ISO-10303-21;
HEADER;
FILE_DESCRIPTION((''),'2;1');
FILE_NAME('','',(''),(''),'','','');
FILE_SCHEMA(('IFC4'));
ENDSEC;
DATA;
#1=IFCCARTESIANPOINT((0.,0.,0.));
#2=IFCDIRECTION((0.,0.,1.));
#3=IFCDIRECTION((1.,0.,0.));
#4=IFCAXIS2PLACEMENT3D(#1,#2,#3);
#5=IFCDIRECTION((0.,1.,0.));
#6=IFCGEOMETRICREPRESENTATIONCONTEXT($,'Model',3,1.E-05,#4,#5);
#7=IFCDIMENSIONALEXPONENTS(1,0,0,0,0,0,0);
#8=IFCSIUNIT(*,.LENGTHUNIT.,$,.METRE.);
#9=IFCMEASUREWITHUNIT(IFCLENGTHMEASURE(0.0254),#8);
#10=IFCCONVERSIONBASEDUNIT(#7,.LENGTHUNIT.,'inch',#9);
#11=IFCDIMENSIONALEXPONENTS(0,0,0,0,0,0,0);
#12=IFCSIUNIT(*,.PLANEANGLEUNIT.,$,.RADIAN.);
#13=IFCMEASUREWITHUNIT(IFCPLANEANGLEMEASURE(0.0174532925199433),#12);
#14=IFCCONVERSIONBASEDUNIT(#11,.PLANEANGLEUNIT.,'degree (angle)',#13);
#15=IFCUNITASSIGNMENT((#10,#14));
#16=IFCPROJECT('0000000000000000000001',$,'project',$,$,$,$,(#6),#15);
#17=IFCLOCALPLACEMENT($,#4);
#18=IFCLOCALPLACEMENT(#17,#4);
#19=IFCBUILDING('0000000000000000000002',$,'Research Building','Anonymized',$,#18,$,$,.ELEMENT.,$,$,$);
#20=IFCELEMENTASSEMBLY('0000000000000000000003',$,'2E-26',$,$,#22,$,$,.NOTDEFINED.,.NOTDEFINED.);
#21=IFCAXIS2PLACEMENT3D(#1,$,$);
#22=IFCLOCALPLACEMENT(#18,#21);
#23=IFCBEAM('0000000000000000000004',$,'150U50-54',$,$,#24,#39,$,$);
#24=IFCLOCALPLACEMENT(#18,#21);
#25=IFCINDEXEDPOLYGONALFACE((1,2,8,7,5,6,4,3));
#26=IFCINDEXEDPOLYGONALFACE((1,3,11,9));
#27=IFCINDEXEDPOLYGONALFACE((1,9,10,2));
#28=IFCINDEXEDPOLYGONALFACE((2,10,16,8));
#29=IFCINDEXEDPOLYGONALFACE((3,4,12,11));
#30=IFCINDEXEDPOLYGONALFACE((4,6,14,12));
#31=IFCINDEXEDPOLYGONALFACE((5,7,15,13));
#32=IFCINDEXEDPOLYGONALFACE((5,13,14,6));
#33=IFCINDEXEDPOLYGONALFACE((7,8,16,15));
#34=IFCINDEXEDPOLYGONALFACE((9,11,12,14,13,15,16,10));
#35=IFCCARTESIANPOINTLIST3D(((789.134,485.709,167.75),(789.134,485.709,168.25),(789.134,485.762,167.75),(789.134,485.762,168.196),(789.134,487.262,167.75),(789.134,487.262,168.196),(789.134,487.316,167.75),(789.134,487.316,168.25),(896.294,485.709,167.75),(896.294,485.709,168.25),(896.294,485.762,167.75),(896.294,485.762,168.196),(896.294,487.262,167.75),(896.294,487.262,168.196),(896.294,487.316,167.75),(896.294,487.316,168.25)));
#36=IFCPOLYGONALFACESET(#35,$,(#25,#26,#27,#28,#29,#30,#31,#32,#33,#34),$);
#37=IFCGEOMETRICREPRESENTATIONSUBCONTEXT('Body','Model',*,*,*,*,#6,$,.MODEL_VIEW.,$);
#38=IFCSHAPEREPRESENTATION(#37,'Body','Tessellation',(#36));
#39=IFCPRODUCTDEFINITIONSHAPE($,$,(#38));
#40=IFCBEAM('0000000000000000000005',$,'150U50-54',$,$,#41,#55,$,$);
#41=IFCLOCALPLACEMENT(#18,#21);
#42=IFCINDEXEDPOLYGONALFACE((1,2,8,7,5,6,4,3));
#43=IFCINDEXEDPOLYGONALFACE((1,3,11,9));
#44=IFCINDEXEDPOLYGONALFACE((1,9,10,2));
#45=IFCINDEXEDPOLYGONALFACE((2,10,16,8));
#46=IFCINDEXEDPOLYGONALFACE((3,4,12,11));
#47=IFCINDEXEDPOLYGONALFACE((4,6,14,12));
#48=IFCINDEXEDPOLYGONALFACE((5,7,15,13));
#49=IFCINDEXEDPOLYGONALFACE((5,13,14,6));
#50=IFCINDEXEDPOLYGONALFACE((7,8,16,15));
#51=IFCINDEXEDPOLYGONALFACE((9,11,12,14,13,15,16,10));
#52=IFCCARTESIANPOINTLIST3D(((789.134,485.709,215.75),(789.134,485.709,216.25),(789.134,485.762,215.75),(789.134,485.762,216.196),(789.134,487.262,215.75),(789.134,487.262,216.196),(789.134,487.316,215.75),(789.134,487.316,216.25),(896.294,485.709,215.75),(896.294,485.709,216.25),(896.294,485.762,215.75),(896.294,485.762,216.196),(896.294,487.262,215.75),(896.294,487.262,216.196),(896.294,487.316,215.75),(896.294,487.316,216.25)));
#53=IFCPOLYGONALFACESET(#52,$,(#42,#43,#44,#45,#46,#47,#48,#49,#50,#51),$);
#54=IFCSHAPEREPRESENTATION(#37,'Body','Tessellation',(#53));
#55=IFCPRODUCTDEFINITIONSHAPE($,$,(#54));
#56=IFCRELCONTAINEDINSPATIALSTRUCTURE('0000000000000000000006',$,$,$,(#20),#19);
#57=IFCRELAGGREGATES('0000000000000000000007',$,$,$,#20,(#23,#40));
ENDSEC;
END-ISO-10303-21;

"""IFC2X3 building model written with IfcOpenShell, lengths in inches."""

from ifc_helpers import new_model, entity, si_unit, converted_unit, direction, frame, origin_with_axes, place, context, subcontext, project, spatial, polyline, segment, composite_curve, outline, extrude, element, aggregate, save


model = new_model("IFC2X3")

# Units and contexts
model_context = context("Model", 3, precision=1e-05, world=origin_with_axes(), true_north=direction((0.0, 1.0, 0.0)))
body_context = subcontext(model_context, "Body", "Model", "MODEL_VIEW")
ifc_project = project(units=[converted_unit("LENGTHUNIT", "inch", entity("IfcLengthMeasure", 0.0254), si_unit("LENGTHUNIT", "METRE"), dimensions=[1, 0, 0, 0, 0, 0, 0]), converted_unit("PLANEANGLEUNIT", "degree (angle)", entity("IfcPlaneAngleMeasure", 0.0174532925199433), si_unit("PLANEANGLEUNIT", "RADIAN"), dimensions=[0, 0, 0, 0, 0, 0, 0])], contexts=[model_context])

# Building
placement = place(None, origin_with_axes())
building_placement = place(placement, origin_with_axes())
building = spatial("IfcBuilding", at=building_placement, Name="Research Building", Description="Anonymized", CompositionType="ELEMENT")

# Element assembly, beams
assembly_placement = place(building_placement, origin_with_axes())
assembly = element("IfcElementAssembly", 1, at=assembly_placement, inside=building, Name="2E-26", AssemblyPlace="NOTDEFINED", PredefinedType="NOTDEFINED")
beam_1_placement = place(assembly_placement, frame((789.134, 486.512, 168.0), z_axis=(1.0, 0.0, 0.0), x_axis=(0.0, 0.0, -1.0)))
beam_1 = element("IfcBeam", 2, at=beam_1_placement, Name="150U50-54", context=body_context, shape_type="SweptSolid", body=[
    extrude(outline(composite_curve([segment(polyline([(-0.25, -0.804), (-0.25, 0.804), (0.25, 0.804), (0.25, 0.75), (-0.196, 0.75), (-0.196, -0.75), (0.25, -0.75), (0.25, -0.804), (-0.25, -0.804)]), True, "CONTINUOUS")], self_intersect=False)), origin_with_axes(), (0.0, 0.0, 1.0), 107.16),
])
beam_2_placement = place(assembly_placement, frame((789.134, 486.512, 216.0), z_axis=(1.0, 0.0, 0.0), x_axis=(0.0, 0.0, -1.0)))
beam_2 = element("IfcBeam", 3, at=beam_2_placement, Name="150U50-54", context=body_context, shape_type="SweptSolid", body=[
    extrude(outline(composite_curve([segment(polyline([(-0.25, -0.804), (-0.25, 0.804), (0.25, 0.804), (0.25, 0.75), (-0.196, 0.75), (-0.196, -0.75), (0.25, -0.75), (0.25, -0.804), (-0.25, -0.804)]), True, "CONTINUOUS")], self_intersect=False)), origin_with_axes(), (0.0, 0.0, 1.0), 107.16),
])
aggregate(assembly, [beam_1, beam_2])

save(model, "model.ifc")
